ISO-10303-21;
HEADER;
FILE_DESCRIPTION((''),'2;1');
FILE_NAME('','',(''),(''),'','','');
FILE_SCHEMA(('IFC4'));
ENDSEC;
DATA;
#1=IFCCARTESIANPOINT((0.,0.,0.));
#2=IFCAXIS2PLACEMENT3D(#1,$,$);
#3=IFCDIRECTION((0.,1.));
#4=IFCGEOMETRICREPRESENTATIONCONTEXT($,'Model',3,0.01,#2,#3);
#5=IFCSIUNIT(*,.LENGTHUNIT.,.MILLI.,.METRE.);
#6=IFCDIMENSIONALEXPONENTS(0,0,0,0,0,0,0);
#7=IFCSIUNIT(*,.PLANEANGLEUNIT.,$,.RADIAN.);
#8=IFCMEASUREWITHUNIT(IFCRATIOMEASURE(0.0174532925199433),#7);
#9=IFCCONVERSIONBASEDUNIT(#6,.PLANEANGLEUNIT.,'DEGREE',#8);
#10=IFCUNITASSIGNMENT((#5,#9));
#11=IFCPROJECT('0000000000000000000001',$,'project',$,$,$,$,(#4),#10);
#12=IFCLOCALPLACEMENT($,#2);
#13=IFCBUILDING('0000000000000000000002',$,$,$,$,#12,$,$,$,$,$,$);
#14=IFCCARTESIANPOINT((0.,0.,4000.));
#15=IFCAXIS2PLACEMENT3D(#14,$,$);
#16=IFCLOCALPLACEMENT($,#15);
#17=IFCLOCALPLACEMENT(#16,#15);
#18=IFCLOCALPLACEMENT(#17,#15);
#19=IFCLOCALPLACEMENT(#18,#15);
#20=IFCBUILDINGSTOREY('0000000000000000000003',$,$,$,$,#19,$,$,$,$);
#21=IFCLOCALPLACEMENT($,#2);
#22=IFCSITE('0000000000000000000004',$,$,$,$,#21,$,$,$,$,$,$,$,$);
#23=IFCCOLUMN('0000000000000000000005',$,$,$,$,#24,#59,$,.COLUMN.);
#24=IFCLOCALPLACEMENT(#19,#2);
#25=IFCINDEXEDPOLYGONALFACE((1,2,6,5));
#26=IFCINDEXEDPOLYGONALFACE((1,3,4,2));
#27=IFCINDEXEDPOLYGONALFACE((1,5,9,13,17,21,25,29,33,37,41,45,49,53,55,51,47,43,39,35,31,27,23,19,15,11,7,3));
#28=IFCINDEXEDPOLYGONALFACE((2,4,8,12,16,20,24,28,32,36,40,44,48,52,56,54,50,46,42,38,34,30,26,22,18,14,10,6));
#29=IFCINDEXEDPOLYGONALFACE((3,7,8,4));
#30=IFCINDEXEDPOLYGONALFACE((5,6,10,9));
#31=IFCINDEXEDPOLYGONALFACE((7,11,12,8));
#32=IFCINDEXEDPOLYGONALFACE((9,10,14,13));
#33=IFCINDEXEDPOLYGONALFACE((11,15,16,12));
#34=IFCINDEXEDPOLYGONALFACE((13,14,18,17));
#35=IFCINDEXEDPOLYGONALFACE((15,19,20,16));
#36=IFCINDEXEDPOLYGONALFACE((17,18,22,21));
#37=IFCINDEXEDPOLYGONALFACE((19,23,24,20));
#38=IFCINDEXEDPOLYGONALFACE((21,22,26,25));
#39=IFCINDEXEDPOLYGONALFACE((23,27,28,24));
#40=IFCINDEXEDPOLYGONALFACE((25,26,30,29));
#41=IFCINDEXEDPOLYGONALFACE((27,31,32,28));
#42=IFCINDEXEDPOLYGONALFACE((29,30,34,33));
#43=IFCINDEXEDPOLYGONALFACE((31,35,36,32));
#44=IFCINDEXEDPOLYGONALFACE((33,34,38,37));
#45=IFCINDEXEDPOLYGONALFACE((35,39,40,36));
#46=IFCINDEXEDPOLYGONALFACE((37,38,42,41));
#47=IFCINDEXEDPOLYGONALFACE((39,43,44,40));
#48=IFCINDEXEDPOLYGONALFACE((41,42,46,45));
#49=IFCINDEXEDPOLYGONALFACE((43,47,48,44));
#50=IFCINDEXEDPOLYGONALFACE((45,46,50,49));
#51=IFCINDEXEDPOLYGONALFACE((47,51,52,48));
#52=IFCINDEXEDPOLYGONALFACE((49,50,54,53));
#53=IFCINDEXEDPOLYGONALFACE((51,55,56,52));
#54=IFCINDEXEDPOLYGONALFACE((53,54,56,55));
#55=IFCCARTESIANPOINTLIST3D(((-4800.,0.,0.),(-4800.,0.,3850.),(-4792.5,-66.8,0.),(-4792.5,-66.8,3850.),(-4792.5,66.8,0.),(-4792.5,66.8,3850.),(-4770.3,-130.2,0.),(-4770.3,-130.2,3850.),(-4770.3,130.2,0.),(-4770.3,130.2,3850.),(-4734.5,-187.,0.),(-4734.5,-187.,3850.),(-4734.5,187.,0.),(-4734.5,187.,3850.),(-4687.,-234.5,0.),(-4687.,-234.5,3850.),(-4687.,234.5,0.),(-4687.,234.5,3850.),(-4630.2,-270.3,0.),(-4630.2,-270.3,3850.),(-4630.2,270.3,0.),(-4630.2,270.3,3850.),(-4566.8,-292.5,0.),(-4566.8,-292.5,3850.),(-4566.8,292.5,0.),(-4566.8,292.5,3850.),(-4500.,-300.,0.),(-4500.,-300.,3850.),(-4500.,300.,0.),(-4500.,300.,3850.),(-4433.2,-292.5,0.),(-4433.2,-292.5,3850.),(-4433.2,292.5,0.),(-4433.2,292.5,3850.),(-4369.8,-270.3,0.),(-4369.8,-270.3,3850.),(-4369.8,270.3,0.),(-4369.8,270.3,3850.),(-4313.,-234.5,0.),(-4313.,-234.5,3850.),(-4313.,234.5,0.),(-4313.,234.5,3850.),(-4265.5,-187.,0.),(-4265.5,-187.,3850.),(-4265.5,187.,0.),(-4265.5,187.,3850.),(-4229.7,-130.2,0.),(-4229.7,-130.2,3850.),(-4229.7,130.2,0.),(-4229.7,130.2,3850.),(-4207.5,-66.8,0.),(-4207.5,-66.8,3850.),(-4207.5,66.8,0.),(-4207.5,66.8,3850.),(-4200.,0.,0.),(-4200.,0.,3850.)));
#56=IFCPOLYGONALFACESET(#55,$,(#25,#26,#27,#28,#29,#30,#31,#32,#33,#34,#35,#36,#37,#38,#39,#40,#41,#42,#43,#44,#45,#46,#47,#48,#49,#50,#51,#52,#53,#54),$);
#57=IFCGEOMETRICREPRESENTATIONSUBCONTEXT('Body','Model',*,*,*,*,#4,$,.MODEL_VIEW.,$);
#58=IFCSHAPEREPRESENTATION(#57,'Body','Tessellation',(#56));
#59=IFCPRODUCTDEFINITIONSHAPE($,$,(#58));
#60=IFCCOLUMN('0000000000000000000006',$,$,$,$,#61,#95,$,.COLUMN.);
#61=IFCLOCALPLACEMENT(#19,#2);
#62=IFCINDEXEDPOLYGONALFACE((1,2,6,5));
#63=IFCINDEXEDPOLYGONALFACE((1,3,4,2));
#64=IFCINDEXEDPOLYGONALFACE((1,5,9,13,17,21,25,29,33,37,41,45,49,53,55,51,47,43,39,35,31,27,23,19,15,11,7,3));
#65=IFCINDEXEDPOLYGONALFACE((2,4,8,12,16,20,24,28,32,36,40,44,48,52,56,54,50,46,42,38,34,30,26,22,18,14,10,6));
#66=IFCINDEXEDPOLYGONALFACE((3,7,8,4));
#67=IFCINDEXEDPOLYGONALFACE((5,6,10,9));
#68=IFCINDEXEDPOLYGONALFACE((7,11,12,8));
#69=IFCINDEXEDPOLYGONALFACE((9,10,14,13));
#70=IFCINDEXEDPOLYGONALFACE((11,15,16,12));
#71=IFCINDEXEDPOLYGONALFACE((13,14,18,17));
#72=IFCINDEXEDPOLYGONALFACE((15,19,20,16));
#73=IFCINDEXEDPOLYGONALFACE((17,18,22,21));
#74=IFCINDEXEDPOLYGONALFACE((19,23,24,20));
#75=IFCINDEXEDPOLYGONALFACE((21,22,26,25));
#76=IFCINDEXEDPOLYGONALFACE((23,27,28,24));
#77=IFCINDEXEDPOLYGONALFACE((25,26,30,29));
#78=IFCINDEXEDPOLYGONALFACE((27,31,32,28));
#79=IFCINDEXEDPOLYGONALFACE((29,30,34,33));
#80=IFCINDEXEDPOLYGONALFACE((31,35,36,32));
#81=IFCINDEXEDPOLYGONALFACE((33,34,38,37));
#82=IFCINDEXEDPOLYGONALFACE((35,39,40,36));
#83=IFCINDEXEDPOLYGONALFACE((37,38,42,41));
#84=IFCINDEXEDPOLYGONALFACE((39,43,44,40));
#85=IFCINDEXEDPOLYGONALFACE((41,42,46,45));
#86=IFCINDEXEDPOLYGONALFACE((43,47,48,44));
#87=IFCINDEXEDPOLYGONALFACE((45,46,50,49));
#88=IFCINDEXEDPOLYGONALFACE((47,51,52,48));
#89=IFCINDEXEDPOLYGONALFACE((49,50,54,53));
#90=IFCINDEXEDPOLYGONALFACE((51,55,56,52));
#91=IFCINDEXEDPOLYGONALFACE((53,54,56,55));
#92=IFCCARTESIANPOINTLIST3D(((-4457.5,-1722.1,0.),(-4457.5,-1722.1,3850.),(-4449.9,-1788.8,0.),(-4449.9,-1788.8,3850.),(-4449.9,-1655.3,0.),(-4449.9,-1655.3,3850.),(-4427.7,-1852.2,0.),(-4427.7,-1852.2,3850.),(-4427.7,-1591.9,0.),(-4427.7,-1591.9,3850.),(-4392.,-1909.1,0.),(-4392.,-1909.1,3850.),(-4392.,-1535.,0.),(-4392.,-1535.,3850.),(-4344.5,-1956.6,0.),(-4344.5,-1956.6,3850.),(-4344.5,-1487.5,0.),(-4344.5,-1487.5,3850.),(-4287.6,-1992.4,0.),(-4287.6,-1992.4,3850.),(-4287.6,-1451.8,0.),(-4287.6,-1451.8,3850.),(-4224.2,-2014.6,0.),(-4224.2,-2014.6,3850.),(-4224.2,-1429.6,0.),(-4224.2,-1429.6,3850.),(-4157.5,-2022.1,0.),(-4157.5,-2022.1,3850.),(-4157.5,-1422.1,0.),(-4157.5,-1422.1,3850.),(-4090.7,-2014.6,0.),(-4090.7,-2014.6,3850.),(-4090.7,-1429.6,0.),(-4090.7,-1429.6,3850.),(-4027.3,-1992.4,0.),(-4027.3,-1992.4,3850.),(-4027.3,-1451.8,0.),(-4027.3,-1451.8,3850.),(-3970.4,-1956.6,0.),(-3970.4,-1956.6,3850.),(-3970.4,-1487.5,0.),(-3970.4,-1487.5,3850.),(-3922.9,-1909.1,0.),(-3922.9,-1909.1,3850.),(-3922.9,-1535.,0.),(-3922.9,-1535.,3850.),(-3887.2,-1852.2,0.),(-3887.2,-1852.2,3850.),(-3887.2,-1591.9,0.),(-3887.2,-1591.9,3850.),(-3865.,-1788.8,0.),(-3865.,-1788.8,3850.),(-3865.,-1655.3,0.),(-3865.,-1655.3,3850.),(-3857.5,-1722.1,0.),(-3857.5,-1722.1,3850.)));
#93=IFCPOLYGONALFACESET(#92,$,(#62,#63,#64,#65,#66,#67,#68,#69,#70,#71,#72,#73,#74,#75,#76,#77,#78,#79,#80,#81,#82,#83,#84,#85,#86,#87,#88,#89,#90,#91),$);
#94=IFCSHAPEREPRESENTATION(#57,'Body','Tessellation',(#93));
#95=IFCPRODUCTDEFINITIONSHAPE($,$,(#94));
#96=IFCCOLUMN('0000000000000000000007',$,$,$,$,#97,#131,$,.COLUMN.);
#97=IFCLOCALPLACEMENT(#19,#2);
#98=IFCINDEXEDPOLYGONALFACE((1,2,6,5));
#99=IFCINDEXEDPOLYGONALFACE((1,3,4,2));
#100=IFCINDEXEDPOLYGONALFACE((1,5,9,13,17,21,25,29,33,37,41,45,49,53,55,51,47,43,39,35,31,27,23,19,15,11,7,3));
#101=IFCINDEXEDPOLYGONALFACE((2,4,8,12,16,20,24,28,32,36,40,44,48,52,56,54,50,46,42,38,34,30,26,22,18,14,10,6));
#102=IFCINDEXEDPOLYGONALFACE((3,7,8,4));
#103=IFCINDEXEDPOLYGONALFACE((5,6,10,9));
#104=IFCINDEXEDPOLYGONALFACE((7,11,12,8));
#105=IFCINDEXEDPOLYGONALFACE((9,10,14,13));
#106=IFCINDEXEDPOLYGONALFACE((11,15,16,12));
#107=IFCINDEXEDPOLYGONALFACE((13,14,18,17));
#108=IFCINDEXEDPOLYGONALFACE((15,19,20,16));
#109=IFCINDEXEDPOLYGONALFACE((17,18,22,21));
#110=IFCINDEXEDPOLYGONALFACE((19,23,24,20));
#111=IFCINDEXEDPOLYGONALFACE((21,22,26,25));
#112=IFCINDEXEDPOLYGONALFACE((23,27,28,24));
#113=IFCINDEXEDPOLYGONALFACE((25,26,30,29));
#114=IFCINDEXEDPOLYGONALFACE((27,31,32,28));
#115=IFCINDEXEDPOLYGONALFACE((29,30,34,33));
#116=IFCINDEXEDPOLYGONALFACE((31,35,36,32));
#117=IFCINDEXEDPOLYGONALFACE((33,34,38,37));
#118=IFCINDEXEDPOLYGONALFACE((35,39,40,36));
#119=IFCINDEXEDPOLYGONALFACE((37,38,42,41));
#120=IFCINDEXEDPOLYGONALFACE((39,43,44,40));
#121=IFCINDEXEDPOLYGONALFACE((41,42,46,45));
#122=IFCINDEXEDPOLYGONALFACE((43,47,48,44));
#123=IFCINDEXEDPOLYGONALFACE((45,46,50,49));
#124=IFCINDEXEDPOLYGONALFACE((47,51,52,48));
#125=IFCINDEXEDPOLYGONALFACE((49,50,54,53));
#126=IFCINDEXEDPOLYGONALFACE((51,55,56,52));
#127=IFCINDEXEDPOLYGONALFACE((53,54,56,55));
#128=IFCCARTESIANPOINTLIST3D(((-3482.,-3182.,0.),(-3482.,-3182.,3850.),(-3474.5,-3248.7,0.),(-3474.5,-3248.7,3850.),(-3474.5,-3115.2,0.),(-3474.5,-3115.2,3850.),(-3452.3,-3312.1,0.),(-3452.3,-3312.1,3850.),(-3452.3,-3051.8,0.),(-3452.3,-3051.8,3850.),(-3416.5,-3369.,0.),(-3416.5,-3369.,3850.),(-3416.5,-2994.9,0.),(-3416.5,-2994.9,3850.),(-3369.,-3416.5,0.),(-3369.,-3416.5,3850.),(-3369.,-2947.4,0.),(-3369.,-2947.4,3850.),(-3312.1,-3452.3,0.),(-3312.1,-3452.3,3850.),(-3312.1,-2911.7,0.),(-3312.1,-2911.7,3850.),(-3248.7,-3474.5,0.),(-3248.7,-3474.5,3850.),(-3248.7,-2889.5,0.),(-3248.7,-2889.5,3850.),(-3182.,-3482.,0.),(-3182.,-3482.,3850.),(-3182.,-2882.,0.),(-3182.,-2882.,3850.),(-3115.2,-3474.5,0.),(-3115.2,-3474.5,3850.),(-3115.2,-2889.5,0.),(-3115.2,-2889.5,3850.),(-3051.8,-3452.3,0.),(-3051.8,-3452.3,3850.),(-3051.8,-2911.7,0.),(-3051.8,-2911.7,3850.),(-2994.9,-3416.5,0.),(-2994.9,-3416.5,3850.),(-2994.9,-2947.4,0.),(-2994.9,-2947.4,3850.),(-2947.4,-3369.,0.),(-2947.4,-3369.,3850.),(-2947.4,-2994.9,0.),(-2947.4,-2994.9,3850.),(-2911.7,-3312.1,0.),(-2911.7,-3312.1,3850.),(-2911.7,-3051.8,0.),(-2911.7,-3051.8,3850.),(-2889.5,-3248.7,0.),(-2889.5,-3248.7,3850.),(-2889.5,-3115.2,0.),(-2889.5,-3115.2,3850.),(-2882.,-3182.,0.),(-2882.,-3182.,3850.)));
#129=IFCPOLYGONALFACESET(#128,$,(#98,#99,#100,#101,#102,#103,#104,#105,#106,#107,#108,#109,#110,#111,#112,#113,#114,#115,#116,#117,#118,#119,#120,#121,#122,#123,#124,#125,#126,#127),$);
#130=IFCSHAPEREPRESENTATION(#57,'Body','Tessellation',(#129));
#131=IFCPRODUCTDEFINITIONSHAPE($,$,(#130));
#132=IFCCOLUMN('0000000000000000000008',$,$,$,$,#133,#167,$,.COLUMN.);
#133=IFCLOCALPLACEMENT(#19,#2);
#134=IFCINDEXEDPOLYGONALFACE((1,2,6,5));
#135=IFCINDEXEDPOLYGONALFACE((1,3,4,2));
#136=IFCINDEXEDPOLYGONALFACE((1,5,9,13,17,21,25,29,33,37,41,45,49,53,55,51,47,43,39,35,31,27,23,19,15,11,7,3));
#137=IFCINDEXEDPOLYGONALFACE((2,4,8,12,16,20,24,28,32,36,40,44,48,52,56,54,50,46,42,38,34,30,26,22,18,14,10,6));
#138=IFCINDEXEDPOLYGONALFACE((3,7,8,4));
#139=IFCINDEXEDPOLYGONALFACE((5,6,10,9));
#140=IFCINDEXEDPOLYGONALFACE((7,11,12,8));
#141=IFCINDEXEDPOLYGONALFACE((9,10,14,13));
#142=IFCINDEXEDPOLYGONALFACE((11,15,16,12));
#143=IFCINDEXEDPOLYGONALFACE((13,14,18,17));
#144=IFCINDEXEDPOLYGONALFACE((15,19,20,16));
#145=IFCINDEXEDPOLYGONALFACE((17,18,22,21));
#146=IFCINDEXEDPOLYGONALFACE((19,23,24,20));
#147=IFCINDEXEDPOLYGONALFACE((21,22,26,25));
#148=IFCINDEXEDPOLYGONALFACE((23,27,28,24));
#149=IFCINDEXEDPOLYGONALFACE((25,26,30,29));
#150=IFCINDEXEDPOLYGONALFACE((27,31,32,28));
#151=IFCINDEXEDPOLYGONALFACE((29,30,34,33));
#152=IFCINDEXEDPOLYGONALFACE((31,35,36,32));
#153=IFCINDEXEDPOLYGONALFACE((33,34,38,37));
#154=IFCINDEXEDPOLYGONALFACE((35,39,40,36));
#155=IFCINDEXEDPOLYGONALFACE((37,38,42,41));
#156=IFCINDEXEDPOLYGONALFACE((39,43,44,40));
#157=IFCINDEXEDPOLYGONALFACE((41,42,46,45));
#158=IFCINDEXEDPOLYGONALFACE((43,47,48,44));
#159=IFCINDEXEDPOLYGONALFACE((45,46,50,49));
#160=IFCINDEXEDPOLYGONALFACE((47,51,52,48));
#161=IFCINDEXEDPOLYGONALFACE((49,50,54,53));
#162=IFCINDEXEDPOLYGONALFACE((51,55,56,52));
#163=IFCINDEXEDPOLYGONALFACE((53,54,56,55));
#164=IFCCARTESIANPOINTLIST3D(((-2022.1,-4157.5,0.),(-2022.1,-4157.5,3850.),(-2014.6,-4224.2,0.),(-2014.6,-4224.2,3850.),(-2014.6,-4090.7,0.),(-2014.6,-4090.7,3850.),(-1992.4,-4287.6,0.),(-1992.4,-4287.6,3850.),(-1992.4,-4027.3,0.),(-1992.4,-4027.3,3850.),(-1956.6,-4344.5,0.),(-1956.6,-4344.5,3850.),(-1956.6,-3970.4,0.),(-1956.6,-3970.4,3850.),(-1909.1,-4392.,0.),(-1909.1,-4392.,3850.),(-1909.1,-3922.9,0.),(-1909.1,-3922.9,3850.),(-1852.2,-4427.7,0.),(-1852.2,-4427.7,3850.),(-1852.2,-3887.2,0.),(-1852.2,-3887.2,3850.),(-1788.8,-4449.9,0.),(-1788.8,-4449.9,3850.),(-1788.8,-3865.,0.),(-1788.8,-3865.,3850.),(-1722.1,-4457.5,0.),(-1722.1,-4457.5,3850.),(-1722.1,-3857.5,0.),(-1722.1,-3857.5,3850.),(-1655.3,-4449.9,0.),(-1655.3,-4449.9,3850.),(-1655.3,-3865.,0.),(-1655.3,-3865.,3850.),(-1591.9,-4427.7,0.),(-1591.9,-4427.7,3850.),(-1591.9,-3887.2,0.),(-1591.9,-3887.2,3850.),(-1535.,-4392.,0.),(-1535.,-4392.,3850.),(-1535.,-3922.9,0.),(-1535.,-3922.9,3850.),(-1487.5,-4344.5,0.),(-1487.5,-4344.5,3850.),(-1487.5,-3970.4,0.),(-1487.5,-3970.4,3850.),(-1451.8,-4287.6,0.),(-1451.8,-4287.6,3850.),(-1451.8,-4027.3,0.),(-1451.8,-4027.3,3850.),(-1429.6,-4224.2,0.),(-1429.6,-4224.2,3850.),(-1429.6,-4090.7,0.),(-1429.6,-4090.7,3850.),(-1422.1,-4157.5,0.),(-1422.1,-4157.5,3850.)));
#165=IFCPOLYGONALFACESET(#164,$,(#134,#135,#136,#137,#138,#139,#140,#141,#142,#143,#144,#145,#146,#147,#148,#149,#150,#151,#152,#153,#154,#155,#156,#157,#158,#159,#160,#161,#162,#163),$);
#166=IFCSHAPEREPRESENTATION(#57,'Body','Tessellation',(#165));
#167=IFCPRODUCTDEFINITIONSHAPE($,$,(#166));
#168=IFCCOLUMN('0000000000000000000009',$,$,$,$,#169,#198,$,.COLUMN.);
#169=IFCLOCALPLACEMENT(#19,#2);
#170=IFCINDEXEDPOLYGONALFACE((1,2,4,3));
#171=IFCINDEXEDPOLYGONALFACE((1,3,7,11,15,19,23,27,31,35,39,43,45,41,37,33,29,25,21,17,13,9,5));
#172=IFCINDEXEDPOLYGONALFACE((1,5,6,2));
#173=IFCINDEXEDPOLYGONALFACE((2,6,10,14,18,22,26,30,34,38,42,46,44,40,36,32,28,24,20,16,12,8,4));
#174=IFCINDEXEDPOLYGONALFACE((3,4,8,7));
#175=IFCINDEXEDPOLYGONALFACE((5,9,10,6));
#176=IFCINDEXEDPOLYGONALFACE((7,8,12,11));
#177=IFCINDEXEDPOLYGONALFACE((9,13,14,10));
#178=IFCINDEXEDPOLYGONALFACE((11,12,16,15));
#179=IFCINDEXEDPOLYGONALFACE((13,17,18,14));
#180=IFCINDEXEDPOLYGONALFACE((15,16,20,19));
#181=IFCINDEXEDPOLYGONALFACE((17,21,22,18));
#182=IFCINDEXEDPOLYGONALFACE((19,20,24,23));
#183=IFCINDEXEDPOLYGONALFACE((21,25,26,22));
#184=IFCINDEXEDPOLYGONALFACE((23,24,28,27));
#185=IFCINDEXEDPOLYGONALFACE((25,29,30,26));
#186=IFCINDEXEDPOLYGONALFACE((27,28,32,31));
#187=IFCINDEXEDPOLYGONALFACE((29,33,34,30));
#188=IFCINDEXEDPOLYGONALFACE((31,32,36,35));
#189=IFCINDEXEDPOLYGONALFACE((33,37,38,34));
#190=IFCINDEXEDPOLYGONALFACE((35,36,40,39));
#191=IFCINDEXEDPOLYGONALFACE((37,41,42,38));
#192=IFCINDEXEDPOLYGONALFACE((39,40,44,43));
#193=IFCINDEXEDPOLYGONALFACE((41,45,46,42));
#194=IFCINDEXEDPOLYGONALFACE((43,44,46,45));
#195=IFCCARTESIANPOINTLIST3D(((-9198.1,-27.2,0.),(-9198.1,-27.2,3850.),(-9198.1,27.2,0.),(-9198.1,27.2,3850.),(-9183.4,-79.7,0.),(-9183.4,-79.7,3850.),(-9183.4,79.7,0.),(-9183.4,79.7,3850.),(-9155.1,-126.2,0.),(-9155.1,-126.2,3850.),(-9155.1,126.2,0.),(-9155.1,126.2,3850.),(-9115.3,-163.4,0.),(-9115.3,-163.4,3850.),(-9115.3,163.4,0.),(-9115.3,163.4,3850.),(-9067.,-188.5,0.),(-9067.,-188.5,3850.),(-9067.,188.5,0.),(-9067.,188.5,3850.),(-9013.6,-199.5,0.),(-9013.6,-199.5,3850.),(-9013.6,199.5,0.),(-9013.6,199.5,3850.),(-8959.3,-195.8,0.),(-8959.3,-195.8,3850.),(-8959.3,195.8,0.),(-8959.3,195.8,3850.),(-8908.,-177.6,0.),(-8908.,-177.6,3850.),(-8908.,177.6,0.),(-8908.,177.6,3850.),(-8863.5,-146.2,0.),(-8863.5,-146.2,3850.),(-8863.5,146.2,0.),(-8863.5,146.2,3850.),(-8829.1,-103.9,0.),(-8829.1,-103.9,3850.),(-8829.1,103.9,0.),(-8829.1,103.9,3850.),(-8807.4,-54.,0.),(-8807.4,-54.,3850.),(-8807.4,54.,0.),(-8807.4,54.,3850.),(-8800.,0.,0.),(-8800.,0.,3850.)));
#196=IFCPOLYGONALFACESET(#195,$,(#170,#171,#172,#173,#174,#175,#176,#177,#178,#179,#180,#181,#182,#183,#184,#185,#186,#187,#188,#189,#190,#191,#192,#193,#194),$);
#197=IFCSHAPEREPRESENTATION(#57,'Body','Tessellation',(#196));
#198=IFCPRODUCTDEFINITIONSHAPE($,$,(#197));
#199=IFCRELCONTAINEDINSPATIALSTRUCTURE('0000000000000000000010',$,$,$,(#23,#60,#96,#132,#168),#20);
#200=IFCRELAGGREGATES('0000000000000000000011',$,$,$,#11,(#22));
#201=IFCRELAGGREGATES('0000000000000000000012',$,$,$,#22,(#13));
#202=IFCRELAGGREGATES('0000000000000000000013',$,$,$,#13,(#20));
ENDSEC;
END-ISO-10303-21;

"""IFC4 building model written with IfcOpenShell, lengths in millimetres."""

from ifc_helpers import new_model, entity, si_unit, converted_unit, direction, frame, origin, origin_2d, place, context, subcontext, project, spatial, circle, extrude, element, save


model = new_model("IFC4")

# Units and contexts
model_context = context("Model", 3, precision=0.01, world=origin(), true_north=direction((0.0, 1.0)))
body_context = subcontext(model_context, "Body", "Model", "MODEL_VIEW")
ifc_project = project(units=[si_unit("LENGTHUNIT", "METRE", prefix="MILLI"), converted_unit("PLANEANGLEUNIT", "DEGREE", entity("IfcRatioMeasure", 0.0174532925199433), si_unit("PLANEANGLEUNIT", "RADIAN"), dimensions=[0, 0, 0, 0, 0, 0, 0])], contexts=[model_context])

# Site, building, storey
site_placement = place(None, origin())
site = spatial("IfcSite", under=ifc_project, at=site_placement)
building_placement = place(None, origin())
building = spatial("IfcBuilding", under=site, at=building_placement)
placement_1 = place(None, frame((0.0, 0.0, 4000.0)))
placement_2 = place(placement_1, frame((0.0, 0.0, 4000.0)))
placement_3 = place(placement_2, frame((0.0, 0.0, 4000.0)))
storey_placement = place(placement_3, frame((0.0, 0.0, 4000.0)))
storey = spatial("IfcBuildingStorey", under=building, at=storey_placement)

# Columns
for number, where in (
    (1, (-4500.0, 0.0, 0.0)),
    (2, (-4157.5, -1722.1, 0.0)),
    (3, (-3182.0, -3182.0, 0.0)),
    (4, (-1722.1, -4157.5, 0.0)),
):
    element("IfcColumn", number, at=place(storey_placement, frame(where)), inside=storey, PredefinedType="COLUMN", context=body_context, shape_type="SweptSolid", body=[
        extrude(circle(Radius=300.0, at=origin_2d()), origin(), (0.0, 0.0, 1.0), 3850.0),
    ])
for number, where in (
    (5, (-9000.0, 0.0, 0.0)),
):
    element("IfcColumn", number, at=place(storey_placement, frame(where)), inside=storey, PredefinedType="COLUMN", context=body_context, shape_type="SweptSolid", body=[
        extrude(circle(Radius=200.0, at=origin_2d()), origin(), (0.0, 0.0, 1.0), 3850.0),
    ])

save(model, "model.ifc")
